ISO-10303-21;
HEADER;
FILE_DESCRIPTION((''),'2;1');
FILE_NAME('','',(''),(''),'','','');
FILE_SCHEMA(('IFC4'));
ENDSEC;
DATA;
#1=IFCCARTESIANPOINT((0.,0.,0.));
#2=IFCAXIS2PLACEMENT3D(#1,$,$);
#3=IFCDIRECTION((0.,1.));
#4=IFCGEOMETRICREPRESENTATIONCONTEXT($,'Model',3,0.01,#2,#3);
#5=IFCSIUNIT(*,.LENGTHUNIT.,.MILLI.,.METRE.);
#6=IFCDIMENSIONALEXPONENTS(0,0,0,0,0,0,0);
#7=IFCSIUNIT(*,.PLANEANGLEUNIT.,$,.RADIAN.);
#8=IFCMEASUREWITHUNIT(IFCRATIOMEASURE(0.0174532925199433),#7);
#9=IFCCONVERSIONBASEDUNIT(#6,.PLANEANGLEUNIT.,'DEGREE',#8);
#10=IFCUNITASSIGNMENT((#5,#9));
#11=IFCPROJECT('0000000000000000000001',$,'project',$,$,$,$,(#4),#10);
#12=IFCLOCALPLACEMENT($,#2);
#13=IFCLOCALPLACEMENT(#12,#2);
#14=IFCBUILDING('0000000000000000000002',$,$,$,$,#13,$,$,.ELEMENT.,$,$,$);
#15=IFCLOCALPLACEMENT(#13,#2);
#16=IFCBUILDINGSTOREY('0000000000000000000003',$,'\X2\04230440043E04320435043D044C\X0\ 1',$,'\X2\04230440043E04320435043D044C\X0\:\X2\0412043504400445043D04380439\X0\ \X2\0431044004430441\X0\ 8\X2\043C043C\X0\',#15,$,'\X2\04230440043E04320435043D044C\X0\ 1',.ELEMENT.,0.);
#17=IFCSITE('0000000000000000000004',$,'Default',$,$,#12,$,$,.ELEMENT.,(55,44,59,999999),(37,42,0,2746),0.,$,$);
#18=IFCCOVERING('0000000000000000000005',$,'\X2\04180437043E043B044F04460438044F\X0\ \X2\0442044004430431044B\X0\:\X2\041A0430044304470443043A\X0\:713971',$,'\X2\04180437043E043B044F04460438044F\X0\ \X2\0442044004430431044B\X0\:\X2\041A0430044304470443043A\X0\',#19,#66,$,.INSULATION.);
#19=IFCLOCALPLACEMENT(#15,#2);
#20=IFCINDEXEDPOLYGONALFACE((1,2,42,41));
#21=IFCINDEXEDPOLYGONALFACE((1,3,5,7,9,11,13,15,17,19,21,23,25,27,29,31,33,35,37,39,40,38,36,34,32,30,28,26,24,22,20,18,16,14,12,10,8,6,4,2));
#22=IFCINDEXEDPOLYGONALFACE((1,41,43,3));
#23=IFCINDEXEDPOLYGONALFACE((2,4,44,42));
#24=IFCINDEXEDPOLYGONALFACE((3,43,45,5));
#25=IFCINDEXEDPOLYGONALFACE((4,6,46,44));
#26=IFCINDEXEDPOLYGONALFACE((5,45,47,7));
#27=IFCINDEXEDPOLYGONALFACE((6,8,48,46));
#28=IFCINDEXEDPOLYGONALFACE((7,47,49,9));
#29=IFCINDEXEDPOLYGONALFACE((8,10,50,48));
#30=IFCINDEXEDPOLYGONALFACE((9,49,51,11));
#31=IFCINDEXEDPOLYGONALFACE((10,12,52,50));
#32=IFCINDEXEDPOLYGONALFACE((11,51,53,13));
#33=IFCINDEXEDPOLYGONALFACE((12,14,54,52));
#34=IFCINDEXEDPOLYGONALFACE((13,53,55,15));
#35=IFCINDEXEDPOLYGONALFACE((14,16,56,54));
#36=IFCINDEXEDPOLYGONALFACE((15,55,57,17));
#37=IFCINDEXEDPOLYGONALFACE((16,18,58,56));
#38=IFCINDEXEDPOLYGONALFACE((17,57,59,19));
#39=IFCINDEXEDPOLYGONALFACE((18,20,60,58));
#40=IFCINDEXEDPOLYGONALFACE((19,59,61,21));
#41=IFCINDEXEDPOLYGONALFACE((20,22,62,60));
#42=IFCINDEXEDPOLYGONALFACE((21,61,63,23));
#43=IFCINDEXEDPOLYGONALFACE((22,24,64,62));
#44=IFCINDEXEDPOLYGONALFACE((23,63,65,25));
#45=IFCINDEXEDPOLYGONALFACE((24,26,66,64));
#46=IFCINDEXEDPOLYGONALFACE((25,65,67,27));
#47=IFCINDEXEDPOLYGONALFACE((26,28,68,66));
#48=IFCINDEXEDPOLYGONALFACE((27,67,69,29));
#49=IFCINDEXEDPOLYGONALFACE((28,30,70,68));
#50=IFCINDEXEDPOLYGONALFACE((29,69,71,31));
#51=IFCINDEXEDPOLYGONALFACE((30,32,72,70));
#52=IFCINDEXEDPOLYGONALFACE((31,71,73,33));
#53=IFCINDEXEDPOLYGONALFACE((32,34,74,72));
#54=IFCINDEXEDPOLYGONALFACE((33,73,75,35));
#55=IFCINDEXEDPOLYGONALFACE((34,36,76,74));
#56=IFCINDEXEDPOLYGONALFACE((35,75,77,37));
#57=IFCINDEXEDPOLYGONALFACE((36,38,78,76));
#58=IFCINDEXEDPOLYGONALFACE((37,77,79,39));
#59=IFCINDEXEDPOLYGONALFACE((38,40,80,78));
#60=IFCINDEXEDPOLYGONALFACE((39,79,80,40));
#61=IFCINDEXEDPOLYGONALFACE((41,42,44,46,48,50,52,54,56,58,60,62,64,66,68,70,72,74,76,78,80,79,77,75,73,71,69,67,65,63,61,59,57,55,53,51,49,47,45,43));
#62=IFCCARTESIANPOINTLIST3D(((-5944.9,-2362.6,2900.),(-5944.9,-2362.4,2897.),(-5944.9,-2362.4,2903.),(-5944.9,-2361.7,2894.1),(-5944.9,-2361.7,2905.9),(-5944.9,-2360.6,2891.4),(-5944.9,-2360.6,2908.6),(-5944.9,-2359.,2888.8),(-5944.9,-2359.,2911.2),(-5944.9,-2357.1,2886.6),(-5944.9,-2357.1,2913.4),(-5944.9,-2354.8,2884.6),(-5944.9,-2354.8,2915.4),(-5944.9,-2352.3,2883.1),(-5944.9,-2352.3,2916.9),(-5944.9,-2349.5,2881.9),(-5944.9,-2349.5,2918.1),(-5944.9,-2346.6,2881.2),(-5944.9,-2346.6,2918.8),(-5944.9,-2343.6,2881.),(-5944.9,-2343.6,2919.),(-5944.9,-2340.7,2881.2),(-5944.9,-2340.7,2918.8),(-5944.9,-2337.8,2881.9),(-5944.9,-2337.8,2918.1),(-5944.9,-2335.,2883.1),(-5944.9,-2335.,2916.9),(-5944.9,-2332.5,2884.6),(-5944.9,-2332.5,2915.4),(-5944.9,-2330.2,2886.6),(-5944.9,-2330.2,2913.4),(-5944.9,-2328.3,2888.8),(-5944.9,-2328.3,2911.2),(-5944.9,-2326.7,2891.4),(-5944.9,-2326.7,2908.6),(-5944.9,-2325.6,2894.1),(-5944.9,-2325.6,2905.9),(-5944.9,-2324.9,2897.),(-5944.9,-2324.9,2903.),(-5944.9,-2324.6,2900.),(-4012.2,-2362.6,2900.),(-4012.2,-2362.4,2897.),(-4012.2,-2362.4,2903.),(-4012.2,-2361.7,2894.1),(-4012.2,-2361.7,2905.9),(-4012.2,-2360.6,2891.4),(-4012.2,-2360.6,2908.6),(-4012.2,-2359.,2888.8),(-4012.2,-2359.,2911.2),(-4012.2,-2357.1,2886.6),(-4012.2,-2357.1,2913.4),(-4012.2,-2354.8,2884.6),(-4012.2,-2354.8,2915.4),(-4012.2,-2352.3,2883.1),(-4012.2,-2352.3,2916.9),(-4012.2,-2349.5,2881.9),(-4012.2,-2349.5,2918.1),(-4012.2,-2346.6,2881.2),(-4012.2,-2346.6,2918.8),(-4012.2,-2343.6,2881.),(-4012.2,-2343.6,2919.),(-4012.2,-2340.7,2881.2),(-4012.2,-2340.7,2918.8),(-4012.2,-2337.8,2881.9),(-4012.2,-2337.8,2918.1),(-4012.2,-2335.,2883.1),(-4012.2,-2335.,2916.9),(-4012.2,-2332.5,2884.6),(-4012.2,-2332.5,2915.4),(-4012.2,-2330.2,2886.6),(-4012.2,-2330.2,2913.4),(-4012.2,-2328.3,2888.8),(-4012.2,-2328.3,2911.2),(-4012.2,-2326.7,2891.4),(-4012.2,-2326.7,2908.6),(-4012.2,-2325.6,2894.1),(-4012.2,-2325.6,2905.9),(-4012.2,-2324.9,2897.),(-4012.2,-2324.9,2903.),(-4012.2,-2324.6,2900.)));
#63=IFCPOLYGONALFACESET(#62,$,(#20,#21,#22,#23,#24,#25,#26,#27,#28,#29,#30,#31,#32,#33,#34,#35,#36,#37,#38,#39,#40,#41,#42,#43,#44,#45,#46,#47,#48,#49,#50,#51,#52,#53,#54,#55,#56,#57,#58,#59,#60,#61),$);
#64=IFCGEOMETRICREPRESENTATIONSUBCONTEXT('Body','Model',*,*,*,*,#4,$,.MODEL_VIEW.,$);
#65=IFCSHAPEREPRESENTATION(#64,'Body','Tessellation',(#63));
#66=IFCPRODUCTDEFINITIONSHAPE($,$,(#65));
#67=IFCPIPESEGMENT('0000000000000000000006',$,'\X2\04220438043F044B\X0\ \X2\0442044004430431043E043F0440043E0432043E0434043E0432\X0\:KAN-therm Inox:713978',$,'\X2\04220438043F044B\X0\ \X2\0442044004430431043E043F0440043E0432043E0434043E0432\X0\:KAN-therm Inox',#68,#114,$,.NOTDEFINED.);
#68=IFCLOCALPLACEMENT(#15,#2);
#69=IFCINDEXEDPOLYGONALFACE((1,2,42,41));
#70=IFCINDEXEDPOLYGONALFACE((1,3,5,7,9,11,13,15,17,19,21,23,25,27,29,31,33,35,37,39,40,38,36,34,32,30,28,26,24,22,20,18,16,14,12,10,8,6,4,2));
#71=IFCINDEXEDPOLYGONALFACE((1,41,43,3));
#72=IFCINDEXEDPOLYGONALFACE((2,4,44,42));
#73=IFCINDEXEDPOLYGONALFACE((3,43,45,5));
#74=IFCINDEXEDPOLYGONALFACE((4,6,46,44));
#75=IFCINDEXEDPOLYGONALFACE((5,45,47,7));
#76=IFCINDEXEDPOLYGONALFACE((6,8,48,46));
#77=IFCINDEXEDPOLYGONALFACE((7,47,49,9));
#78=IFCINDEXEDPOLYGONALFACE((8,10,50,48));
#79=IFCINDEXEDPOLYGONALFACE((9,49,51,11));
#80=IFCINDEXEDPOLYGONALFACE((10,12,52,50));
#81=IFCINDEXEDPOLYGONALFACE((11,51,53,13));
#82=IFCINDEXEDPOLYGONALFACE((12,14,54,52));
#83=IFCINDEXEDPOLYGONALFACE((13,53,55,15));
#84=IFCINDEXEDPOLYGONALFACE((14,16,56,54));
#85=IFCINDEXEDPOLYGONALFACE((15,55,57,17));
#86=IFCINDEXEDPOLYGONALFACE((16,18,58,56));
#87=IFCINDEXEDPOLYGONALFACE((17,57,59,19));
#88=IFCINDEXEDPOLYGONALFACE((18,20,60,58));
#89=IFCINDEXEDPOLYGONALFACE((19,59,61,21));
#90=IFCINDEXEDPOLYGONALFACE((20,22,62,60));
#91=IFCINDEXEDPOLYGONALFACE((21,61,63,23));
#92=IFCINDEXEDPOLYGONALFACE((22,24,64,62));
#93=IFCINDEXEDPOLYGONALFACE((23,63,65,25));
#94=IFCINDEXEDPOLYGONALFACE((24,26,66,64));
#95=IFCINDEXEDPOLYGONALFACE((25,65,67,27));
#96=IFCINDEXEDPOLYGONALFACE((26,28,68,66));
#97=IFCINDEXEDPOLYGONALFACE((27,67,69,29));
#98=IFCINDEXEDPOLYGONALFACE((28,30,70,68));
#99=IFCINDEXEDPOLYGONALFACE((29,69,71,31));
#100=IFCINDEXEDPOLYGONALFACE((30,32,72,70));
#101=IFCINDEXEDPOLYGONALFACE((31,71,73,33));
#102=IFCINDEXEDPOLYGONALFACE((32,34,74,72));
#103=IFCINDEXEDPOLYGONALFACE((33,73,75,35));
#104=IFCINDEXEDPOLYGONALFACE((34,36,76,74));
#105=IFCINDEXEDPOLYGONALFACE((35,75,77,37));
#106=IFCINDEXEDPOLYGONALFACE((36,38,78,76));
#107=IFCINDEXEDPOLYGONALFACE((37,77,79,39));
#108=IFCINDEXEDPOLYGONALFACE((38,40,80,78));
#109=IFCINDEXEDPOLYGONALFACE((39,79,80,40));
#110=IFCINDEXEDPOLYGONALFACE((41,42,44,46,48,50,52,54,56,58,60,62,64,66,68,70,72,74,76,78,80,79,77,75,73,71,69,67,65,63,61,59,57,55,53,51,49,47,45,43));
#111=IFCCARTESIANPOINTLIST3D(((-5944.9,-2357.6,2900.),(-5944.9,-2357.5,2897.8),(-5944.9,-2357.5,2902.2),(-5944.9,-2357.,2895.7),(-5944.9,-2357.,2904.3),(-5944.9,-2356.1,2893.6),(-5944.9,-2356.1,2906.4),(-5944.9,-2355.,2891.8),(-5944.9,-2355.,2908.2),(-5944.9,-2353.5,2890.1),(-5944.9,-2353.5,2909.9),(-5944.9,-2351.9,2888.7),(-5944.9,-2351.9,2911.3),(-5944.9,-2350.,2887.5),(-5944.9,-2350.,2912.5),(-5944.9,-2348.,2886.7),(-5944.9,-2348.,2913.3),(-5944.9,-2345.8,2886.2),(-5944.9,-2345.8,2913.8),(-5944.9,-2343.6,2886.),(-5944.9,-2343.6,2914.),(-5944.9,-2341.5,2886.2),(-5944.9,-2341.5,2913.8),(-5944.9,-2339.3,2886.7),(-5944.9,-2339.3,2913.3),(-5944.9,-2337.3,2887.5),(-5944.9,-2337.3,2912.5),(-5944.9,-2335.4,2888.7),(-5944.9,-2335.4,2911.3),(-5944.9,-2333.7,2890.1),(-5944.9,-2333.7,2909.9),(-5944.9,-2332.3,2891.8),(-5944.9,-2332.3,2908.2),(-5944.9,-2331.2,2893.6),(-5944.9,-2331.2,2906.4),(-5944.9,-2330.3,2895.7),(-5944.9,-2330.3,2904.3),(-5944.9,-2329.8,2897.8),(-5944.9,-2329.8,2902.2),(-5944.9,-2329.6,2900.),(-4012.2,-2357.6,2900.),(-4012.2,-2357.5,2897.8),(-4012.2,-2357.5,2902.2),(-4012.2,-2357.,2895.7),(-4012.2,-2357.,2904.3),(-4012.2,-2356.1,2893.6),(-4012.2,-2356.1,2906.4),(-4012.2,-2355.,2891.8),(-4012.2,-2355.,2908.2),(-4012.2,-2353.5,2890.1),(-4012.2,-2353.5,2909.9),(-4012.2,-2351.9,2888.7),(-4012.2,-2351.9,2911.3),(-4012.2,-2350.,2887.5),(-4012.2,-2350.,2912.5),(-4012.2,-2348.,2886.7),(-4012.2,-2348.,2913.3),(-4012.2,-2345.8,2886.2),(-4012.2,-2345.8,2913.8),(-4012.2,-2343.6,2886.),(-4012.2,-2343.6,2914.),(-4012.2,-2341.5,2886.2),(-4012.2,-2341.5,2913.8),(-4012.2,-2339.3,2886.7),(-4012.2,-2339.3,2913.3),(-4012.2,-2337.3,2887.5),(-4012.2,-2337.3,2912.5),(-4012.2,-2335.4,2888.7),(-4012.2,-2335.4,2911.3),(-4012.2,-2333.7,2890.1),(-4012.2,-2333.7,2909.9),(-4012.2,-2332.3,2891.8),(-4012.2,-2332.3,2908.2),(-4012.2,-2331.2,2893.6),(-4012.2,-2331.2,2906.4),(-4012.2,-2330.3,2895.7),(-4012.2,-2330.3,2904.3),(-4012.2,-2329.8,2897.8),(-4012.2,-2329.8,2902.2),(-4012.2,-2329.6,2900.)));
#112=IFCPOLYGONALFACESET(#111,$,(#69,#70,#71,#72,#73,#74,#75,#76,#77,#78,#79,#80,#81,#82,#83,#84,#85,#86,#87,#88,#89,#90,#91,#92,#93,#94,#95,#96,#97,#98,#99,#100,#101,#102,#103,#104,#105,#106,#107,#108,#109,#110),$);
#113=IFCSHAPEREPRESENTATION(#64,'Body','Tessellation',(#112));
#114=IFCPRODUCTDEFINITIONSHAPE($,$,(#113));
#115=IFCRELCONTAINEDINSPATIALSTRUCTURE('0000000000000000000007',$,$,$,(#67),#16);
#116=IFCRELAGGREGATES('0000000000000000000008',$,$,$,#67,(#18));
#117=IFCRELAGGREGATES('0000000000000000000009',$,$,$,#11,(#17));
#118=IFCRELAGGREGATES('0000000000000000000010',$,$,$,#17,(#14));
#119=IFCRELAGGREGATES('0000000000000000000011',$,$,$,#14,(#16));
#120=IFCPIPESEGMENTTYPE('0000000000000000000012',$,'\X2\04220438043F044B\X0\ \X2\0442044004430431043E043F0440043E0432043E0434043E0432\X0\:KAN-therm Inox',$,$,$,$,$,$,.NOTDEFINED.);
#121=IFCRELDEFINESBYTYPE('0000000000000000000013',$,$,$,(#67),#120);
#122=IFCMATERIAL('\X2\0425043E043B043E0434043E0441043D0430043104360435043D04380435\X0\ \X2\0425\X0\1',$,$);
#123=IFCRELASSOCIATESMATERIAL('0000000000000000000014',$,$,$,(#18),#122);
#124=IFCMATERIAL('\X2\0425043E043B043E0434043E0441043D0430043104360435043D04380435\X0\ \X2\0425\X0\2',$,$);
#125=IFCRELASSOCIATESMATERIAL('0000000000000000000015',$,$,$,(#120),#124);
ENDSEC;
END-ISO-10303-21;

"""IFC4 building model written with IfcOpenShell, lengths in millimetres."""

from ifc_helpers import new_model, entity, si_unit, converted_unit, direction, frame, origin, place, context, subcontext, project, spatial, indexed_curve, outline, extrude, material, type_object, element, aggregate, save


model = new_model("IFC4")

# Units and contexts
model_context = context("Model", 3, precision=0.01, world=origin(), true_north=direction((0.0, 1.0)))
body_context = subcontext(model_context, "Body", "Model", "MODEL_VIEW")
ifc_project = project(units=[si_unit("LENGTHUNIT", "METRE", prefix="MILLI"), converted_unit("PLANEANGLEUNIT", "DEGREE", entity("IfcRatioMeasure", 0.0174532925199433), si_unit("PLANEANGLEUNIT", "RADIAN"), dimensions=[0, 0, 0, 0, 0, 0, 0])], contexts=[model_context])

# Site, building, storey
site_placement = place(None, origin())
site = spatial("IfcSite", under=ifc_project, at=site_placement, Name="Default", CompositionType="ELEMENT", RefLatitude=(55, 44, 59, 999999), RefLongitude=(37, 42, 0, 2746), RefElevation=0.0)
building_placement = place(site_placement, origin())
building = spatial("IfcBuilding", under=site, at=building_placement, CompositionType="ELEMENT")
storey_placement = place(building_placement, origin())
storey = spatial("IfcBuildingStorey", under=building, at=storey_placement, Name="Уровень 1", ObjectType="Уровень:Верхний брус 8мм", LongName="Уровень 1", CompositionType="ELEMENT", Elevation=0.0)

# Covering
ifc_material_1 = material(Name="Холодоснабжение Х2")
ifc_material_2 = material(Name="Холодоснабжение Х1")
covering_1_placement = place(storey_placement, origin())
covering_1 = element("IfcCovering", 1, at=covering_1_placement, material=ifc_material_2, Name="Изоляция трубы:Каучук:713971", ObjectType="Изоляция трубы:Каучук", PredefinedType="INSULATION", context=body_context, shape_type="SweptSolid", body=[
    extrude(outline(indexed_curve([(19.0, 0.0), (18.8, 3.0), (18.1, 5.9), (16.9, 8.6), (15.4, 11.2), (13.4, 13.4), (11.2, 15.4), (8.6, 16.9), (5.9, 18.1), (3.0, 18.8), (0.0, 19.0), (-3.0, 18.8), (-5.9, 18.1), (-8.6, 16.9), (-11.2, 15.4), (-13.4, 13.4), (-15.4, 11.2), (-16.9, 8.6), (-18.1, 5.9), (-18.8, 3.0), (-19.0, 0.0), (-18.8, -3.0), (-18.1, -5.9), (-16.9, -8.6), (-15.4, -11.2), (-13.4, -13.4), (-11.2, -15.4), (-8.6, -16.9), (-5.9, -18.1), (-3.0, -18.8), (0.0, -19.0), (3.0, -18.8), (5.9, -18.1), (8.6, -16.9), (11.2, -15.4), (13.4, -13.4), (15.4, -11.2), (16.9, -8.6), (18.1, -5.9), (18.8, -3.0), (19.0, 0.0)], self_intersect=False)), frame((-5944.9, -2343.6, 2900.0), z_axis=(1.0, 0.0, 0.0), x_axis=(0.0, -1.0, 0.0)), (0.0, 0.0, 1.0), 1932.8),
])

# Pipe segment
pipe_segment_type_1 = type_object("IfcPipeSegmentType", Name="Типы трубопроводов:KAN-therm Inox", PredefinedType="NOTDEFINED", material=ifc_material_1)
pipe_segment_1_placement = place(storey_placement, origin())
pipe_segment_1 = element("IfcPipeSegment", 2, at=pipe_segment_1_placement, inside=storey, type_object=pipe_segment_type_1, Name="Типы трубопроводов:KAN-therm Inox:713978", ObjectType="Типы трубопроводов:KAN-therm Inox", PredefinedType="NOTDEFINED", context=body_context, shape_type="SweptSolid", body=[
    extrude(outline(indexed_curve([(14.0, 0.0), (13.8, 2.2), (13.3, 4.3), (12.5, 6.4), (11.3, 8.2), (9.9, 9.9), (8.2, 11.3), (6.4, 12.5), (4.3, 13.3), (2.2, 13.8), (0.0, 14.0), (-2.2, 13.8), (-4.3, 13.3), (-6.4, 12.5), (-8.2, 11.3), (-9.9, 9.9), (-11.3, 8.2), (-12.5, 6.4), (-13.3, 4.3), (-13.8, 2.2), (-14.0, 0.0), (-13.8, -2.2), (-13.3, -4.3), (-12.5, -6.4), (-11.3, -8.2), (-9.9, -9.9), (-8.2, -11.3), (-6.4, -12.5), (-4.3, -13.3), (-2.2, -13.8), (0.0, -14.0), (2.2, -13.8), (4.3, -13.3), (6.4, -12.5), (8.2, -11.3), (9.9, -9.9), (11.3, -8.2), (12.5, -6.4), (13.3, -4.3), (13.8, -2.2), (14.0, 0.0)], self_intersect=False)), frame((-5944.9, -2343.6, 2900.0), z_axis=(1.0, 0.0, 0.0), x_axis=(0.0, 1.0, 0.0)), (0.0, 0.0, 1.0), 1932.8),
])
aggregate(pipe_segment_1, [covering_1])

save(model, "model.ifc")
